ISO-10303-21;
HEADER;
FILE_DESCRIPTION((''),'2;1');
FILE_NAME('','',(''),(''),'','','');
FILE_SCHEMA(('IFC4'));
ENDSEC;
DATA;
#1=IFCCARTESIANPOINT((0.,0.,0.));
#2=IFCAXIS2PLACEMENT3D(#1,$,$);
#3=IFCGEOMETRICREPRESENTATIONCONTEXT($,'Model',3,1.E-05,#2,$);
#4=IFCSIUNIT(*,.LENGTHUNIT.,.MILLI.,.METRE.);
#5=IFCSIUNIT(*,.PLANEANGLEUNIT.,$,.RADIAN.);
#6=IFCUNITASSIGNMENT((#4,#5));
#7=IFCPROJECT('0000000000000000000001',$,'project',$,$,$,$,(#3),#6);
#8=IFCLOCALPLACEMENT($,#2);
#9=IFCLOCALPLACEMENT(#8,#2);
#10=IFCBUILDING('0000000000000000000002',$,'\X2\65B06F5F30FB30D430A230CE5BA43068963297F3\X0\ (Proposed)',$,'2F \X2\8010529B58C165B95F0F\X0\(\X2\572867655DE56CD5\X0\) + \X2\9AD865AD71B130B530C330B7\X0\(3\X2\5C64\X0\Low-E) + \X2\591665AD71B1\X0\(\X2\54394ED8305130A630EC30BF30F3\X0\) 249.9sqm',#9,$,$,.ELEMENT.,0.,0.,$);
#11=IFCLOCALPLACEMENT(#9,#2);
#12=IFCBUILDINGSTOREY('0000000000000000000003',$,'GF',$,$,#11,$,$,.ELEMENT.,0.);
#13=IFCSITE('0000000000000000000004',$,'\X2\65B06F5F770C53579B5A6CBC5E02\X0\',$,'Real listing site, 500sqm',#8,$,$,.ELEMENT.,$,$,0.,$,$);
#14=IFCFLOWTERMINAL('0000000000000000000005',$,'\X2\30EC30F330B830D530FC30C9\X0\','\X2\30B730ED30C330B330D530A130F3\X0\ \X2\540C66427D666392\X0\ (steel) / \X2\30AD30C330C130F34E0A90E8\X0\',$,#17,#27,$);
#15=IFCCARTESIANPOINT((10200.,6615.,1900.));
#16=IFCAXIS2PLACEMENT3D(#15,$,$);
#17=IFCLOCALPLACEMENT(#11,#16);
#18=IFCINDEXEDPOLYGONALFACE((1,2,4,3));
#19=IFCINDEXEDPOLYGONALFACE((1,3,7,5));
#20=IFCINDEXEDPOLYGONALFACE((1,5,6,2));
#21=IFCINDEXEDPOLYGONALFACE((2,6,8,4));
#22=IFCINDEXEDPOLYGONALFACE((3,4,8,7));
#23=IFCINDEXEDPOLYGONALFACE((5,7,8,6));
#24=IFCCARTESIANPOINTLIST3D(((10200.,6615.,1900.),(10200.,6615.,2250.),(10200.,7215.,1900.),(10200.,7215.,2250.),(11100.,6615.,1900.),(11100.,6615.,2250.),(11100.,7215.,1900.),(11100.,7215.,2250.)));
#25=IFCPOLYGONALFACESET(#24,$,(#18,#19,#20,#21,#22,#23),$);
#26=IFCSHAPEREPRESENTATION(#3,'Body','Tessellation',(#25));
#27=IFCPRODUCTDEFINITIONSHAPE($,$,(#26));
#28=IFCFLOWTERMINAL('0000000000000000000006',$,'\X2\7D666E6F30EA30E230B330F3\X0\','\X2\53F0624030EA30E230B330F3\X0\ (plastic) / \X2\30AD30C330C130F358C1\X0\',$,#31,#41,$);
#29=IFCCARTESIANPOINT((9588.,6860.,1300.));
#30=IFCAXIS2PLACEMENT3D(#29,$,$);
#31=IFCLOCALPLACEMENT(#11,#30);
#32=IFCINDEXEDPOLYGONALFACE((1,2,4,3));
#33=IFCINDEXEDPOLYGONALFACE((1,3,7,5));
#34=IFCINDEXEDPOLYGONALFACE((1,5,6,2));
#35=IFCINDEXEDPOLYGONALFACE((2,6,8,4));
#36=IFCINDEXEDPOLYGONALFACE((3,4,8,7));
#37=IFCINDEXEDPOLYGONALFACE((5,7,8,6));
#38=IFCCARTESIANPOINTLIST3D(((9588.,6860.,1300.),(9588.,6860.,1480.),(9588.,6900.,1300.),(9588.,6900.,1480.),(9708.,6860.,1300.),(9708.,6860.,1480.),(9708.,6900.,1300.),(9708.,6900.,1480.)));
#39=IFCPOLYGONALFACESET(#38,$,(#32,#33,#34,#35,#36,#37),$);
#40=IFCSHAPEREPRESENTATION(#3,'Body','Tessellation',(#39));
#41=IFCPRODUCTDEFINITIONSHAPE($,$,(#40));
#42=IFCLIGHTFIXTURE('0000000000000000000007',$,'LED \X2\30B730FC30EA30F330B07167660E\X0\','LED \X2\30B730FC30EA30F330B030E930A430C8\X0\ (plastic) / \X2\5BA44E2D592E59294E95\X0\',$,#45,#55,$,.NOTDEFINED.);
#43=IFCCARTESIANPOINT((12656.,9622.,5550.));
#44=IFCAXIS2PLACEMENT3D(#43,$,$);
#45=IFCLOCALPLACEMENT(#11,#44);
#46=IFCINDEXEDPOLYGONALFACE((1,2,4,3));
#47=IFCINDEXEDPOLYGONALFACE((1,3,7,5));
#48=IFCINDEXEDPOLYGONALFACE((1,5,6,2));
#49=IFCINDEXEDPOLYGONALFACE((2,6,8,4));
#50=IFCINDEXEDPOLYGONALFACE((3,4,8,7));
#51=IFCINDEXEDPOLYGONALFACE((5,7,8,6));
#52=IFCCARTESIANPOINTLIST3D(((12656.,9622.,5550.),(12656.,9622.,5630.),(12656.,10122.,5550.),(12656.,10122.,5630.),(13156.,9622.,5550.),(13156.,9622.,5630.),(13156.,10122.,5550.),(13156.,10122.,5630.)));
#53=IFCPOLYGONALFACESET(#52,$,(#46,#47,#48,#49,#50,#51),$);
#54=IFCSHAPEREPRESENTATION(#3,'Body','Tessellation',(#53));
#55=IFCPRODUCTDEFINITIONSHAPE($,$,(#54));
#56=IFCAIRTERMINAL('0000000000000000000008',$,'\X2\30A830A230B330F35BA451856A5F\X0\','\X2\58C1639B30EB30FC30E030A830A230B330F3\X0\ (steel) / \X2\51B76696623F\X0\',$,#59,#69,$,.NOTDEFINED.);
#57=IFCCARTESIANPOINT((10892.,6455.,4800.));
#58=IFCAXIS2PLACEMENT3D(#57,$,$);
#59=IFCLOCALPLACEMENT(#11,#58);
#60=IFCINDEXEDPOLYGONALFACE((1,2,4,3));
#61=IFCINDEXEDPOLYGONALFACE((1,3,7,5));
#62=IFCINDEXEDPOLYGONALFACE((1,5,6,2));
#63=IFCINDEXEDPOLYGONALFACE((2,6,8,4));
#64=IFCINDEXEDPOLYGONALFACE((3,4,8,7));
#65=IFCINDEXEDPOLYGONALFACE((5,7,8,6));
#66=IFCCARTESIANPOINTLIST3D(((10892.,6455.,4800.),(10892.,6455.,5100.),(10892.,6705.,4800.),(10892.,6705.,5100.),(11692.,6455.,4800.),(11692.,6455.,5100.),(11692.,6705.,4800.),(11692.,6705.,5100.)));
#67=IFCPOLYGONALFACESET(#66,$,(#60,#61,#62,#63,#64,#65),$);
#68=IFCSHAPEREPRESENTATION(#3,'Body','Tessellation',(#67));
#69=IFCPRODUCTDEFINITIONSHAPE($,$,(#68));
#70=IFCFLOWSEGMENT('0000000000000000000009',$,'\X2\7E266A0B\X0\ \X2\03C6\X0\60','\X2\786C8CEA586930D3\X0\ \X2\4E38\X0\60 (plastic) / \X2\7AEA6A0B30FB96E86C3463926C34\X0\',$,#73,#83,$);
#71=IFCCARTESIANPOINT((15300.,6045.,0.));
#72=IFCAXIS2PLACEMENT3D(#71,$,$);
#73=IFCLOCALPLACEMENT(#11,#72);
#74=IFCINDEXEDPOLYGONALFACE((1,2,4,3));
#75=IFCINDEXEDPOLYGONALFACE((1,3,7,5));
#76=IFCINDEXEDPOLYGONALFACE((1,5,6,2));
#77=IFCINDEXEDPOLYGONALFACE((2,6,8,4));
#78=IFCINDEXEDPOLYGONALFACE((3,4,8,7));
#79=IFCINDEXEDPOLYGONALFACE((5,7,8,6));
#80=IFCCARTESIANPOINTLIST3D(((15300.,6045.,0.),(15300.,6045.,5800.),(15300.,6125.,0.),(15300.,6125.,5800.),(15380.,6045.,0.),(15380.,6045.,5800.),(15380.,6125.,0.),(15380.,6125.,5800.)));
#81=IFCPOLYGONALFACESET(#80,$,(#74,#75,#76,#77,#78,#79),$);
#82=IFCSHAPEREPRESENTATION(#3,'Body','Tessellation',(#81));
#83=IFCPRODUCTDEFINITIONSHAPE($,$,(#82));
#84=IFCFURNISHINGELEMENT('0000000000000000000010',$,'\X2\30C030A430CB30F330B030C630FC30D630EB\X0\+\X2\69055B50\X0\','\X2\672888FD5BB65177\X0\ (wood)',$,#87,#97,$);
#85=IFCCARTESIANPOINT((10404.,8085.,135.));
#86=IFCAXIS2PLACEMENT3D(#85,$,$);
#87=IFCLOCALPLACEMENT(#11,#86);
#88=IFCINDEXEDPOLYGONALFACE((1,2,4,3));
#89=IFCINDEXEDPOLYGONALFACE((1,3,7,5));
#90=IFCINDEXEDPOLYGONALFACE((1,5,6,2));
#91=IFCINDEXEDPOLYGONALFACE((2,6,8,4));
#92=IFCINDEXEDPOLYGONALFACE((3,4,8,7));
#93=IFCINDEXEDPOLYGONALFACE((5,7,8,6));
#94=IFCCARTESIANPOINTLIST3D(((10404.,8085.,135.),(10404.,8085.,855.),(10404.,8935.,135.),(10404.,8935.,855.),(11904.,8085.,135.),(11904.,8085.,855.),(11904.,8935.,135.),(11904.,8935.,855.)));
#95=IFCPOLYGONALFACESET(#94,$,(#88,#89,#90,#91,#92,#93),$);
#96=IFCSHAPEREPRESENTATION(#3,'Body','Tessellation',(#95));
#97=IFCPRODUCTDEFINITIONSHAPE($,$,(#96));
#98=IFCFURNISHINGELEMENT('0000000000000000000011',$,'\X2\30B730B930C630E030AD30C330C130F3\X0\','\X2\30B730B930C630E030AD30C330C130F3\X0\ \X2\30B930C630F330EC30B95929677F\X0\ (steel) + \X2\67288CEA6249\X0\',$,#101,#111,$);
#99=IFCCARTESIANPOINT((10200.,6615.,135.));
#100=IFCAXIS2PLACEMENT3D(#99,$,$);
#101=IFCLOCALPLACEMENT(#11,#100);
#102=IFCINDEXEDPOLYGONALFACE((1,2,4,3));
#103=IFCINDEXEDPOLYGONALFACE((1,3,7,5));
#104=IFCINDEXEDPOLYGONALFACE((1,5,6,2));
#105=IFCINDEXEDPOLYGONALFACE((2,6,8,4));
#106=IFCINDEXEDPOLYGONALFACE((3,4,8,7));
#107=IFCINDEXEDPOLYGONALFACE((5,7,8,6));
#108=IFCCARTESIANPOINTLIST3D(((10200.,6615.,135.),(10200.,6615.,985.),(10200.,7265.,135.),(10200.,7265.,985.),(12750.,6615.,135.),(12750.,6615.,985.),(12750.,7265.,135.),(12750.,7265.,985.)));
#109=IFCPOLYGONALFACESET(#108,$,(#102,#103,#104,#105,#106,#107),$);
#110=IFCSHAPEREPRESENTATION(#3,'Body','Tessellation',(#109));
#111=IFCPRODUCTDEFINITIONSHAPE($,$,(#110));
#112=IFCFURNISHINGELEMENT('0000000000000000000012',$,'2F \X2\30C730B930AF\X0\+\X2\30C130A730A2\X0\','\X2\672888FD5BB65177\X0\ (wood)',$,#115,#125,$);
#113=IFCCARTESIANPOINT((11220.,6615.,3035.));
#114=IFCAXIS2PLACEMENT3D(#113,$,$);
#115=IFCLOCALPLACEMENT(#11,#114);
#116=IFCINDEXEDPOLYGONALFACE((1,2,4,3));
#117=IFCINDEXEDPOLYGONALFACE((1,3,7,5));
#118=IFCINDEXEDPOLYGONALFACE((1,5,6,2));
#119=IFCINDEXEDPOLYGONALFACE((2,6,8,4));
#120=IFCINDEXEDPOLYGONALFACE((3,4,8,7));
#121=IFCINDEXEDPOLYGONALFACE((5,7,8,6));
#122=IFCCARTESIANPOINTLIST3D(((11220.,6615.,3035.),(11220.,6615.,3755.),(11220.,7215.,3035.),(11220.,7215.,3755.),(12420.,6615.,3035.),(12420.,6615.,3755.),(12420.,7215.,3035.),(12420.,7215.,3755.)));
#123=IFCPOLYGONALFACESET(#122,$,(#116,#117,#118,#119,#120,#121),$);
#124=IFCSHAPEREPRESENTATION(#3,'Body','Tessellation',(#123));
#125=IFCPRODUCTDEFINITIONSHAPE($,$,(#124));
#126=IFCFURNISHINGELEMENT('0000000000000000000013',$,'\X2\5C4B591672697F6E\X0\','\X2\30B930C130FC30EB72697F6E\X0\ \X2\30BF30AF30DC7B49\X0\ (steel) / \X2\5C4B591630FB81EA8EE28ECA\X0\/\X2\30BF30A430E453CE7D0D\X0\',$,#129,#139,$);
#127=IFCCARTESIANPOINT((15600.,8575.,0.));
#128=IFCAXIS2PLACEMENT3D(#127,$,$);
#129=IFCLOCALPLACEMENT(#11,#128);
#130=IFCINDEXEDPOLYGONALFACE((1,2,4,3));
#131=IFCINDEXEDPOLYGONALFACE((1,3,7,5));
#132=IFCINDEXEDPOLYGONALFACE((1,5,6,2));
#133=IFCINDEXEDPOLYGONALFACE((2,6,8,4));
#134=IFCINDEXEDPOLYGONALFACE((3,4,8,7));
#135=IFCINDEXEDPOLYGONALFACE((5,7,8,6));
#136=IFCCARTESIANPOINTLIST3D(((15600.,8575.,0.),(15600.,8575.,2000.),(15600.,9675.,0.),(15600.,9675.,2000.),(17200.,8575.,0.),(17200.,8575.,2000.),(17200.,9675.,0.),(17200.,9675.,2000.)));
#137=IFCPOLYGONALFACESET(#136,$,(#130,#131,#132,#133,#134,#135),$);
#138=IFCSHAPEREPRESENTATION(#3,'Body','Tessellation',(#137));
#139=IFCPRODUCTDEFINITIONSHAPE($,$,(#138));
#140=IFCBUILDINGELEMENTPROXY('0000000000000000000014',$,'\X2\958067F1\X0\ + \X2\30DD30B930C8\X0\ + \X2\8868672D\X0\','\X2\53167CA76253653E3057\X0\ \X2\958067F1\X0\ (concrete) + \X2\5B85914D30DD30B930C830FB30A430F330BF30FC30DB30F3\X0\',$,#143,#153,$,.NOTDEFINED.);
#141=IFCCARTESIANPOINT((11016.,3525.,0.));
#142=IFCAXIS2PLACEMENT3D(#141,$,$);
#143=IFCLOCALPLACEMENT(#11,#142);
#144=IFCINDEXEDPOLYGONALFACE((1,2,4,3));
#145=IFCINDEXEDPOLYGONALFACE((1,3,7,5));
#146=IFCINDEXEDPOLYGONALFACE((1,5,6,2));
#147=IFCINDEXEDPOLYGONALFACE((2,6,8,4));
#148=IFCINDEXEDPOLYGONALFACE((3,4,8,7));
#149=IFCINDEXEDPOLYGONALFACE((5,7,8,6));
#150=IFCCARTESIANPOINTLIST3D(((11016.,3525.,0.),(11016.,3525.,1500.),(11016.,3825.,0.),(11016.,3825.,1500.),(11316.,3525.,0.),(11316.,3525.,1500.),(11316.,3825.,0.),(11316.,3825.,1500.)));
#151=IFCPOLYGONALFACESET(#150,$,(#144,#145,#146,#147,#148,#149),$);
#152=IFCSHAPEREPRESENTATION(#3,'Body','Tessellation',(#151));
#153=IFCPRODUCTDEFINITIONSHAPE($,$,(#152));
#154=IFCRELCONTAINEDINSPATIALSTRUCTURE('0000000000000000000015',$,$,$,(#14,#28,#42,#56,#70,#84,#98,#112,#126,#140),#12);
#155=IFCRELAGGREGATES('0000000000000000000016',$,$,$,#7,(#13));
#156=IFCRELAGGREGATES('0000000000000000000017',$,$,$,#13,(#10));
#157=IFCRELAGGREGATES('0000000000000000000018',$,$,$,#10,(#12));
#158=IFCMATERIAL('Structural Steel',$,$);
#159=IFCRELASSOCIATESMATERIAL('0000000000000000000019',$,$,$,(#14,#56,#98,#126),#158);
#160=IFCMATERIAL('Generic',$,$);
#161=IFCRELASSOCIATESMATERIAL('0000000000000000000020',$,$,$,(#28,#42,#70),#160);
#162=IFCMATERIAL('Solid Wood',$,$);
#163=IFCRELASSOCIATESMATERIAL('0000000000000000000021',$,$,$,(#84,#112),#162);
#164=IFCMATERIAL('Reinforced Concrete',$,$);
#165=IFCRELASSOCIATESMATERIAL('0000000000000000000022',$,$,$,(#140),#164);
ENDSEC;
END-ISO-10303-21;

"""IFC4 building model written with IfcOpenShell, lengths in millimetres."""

from ifc_helpers import new_model, si_unit, frame, frame_2d, origin, place, context, project, spatial, rectangle, extrude, material, element, save


model = new_model("IFC4")

# Units and contexts
model_context = context("Model", 3, precision=1e-05, world=origin())
ifc_project = project(units=[si_unit("LENGTHUNIT", "METRE", prefix="MILLI"), si_unit("PLANEANGLEUNIT", "RADIAN")], contexts=[model_context])

# Site, building, storey
site_placement = place(None, origin())
site = spatial("IfcSite", under=ifc_project, at=site_placement, Name="新潟県南魚沼市", ObjectType="Real listing site, 500sqm", CompositionType="ELEMENT", RefElevation=0.0)
building_placement = place(site_placement, origin())
building = spatial("IfcBuilding", under=site, at=building_placement, Name="新潟・ピアノ室と防音 (Proposed)", ObjectType="2F 耐力壁方式(在来工法) + 高断熱サッシ(3層Low-E) + 外断熱(吹付けウレタン) 249.9sqm", CompositionType="ELEMENT", ElevationOfRefHeight=0.0, ElevationOfTerrain=0.0)
storey_placement = place(building_placement, origin())
storey = spatial("IfcBuildingStorey", under=building, at=storey_placement, Name="GF", CompositionType="ELEMENT", Elevation=0.0)

# Shared definitions
ifc_material_1 = material(Name="Solid Wood")

# Shared definitions
ifc_material_2 = material(Name="Reinforced Concrete")

# Shared definitions
ifc_material_3 = material(Name="Structural Steel")

# Flow terminals
flow_terminal_1_placement = place(storey_placement, frame((10200.0, 6615.0, 1900.0)))
element("IfcFlowTerminal", 1, at=flow_terminal_1_placement, inside=storey, material=ifc_material_3, Name="レンジフード", Description="シロッコファン 同時給排 (steel) / キッチン上部", context=model_context, shape_type="SweptSolid", body=[
    extrude(rectangle(XDim=900.0, YDim=600.0, at=frame_2d((450.0, 300.0))), frame((10200.0, 6615.0, 1900.0)), (0.0, 0.0, 1.0), 350.0),
])
ifc_material_4 = material(Name="Generic")
flow_terminal_2_placement = place(storey_placement, frame((9588.0, 6860.0, 1300.0)))
element("IfcFlowTerminal", 2, at=flow_terminal_2_placement, inside=storey, material=ifc_material_4, Name="給湯リモコン", Description="台所リモコン (plastic) / キッチン壁", context=model_context, shape_type="SweptSolid", body=[
    extrude(rectangle(XDim=120.0, YDim=40.0, at=frame_2d((60.0, 20.0))), frame((9588.0, 6860.0, 1300.0)), (0.0, 0.0, 1.0), 180.0),
])

# Light fixture
light_fixture_placement = place(storey_placement, frame((12656.0, 9622.0, 5550.0)))
element("IfcLightFixture", 3, at=light_fixture_placement, inside=storey, material=ifc_material_4, Name="LED シーリング照明", Description="LED シーリングライト (plastic) / 室中央天井", PredefinedType="NOTDEFINED", context=model_context, shape_type="SweptSolid", body=[
    extrude(rectangle(XDim=500.0, YDim=500.0, at=frame_2d((250.0, 250.0))), frame((12656.0, 9622.0, 5550.0)), (0.0, 0.0, 1.0), 80.0),
])

# Air terminal
air_terminal_placement = place(storey_placement, frame((10892.0, 6455.0, 4800.0)))
element("IfcAirTerminal", 4, at=air_terminal_placement, inside=storey, material=ifc_material_3, Name="エアコン室内機", Description="壁掛ルームエアコン (steel) / 冷暖房", PredefinedType="NOTDEFINED", context=model_context, shape_type="SweptSolid", body=[
    extrude(rectangle(XDim=800.0, YDim=250.0, at=frame_2d((400.0, 125.0))), frame((10892.0, 6455.0, 4800.0)), (0.0, 0.0, 1.0), 300.0),
])

# Flow segment
flow_segment_placement = place(storey_placement, frame((15300.0, 6045.0, 0.0)))
element("IfcFlowSegment", 5, at=flow_segment_placement, inside=storey, material=ifc_material_4, Name="縦樋 φ60", Description="硬質塩ビ 丸60 (plastic) / 竪樋・雨水排水", context=model_context, shape_type="SweptSolid", body=[
    extrude(rectangle(XDim=80.0, YDim=80.0, at=frame_2d((40.0, 40.0))), frame((15300.0, 6045.0, 0.0)), (0.0, 0.0, 1.0), 5800.0),
])

# Furnishing elements
furnishing_1_placement = place(storey_placement, frame((10404.0, 8085.0, 135.0)))
element("IfcFurnishingElement", 6, at=furnishing_1_placement, inside=storey, material=ifc_material_1, Name="ダイニングテーブル+椅子", Description="木製家具 (wood)", context=model_context, shape_type="SweptSolid", body=[
    extrude(rectangle(XDim=1500.0, YDim=850.0, at=frame_2d((750.0, 425.0))), frame((10404.0, 8085.0, 135.0)), (0.0, 0.0, 1.0), 720.0),
])
furnishing_2_placement = place(storey_placement, frame((10200.0, 6615.0, 135.0)))
element("IfcFurnishingElement", 7, at=furnishing_2_placement, inside=storey, material=ifc_material_3, Name="システムキッチン", Description="システムキッチン ステンレス天板 (steel) + 木質扉", context=model_context, shape_type="SweptSolid", body=[
    extrude(rectangle(XDim=2550.0, YDim=650.0, at=frame_2d((1275.0, 325.0))), frame((10200.0, 6615.0, 135.0)), (0.0, 0.0, 1.0), 850.0),
])
furnishing_3_placement = place(storey_placement, frame((11220.0, 6615.0, 3035.0)))
element("IfcFurnishingElement", 8, at=furnishing_3_placement, inside=storey, material=ifc_material_1, Name="2F デスク+チェア", Description="木製家具 (wood)", context=model_context, shape_type="SweptSolid", body=[
    extrude(rectangle(XDim=1200.0, YDim=600.0, at=frame_2d((600.0, 300.0))), frame((11220.0, 6615.0, 3035.0)), (0.0, 0.0, 1.0), 720.0),
])
furnishing_4_placement = place(storey_placement, frame((15600.0, 8575.0, 0.0)))
element("IfcFurnishingElement", 9, at=furnishing_4_placement, inside=storey, material=ifc_material_3, Name="屋外物置", Description="スチール物置 タクボ等 (steel) / 屋外・自転車/タイヤ収納", context=model_context, shape_type="SweptSolid", body=[
    extrude(rectangle(XDim=1600.0, YDim=1100.0, at=frame_2d((800.0, 550.0))), frame((15600.0, 8575.0, 0.0)), (0.0, 0.0, 1.0), 2000.0),
])

# Building element proxy
proxy_placement = place(storey_placement, frame((11016.0, 3525.0, 0.0)))
element("IfcBuildingElementProxy", 10, at=proxy_placement, inside=storey, material=ifc_material_2, Name="門柱 + ポスト + 表札", Description="化粧打放し 門柱 (concrete) + 宅配ポスト・インターホン", PredefinedType="NOTDEFINED", context=model_context, shape_type="SweptSolid", body=[
    extrude(rectangle(XDim=300.0, YDim=300.0, at=frame_2d((150.0, 150.0))), frame((11016.0, 3525.0, 0.0)), (0.0, 0.0, 1.0), 1500.0),
])

save(model, "model.ifc")
